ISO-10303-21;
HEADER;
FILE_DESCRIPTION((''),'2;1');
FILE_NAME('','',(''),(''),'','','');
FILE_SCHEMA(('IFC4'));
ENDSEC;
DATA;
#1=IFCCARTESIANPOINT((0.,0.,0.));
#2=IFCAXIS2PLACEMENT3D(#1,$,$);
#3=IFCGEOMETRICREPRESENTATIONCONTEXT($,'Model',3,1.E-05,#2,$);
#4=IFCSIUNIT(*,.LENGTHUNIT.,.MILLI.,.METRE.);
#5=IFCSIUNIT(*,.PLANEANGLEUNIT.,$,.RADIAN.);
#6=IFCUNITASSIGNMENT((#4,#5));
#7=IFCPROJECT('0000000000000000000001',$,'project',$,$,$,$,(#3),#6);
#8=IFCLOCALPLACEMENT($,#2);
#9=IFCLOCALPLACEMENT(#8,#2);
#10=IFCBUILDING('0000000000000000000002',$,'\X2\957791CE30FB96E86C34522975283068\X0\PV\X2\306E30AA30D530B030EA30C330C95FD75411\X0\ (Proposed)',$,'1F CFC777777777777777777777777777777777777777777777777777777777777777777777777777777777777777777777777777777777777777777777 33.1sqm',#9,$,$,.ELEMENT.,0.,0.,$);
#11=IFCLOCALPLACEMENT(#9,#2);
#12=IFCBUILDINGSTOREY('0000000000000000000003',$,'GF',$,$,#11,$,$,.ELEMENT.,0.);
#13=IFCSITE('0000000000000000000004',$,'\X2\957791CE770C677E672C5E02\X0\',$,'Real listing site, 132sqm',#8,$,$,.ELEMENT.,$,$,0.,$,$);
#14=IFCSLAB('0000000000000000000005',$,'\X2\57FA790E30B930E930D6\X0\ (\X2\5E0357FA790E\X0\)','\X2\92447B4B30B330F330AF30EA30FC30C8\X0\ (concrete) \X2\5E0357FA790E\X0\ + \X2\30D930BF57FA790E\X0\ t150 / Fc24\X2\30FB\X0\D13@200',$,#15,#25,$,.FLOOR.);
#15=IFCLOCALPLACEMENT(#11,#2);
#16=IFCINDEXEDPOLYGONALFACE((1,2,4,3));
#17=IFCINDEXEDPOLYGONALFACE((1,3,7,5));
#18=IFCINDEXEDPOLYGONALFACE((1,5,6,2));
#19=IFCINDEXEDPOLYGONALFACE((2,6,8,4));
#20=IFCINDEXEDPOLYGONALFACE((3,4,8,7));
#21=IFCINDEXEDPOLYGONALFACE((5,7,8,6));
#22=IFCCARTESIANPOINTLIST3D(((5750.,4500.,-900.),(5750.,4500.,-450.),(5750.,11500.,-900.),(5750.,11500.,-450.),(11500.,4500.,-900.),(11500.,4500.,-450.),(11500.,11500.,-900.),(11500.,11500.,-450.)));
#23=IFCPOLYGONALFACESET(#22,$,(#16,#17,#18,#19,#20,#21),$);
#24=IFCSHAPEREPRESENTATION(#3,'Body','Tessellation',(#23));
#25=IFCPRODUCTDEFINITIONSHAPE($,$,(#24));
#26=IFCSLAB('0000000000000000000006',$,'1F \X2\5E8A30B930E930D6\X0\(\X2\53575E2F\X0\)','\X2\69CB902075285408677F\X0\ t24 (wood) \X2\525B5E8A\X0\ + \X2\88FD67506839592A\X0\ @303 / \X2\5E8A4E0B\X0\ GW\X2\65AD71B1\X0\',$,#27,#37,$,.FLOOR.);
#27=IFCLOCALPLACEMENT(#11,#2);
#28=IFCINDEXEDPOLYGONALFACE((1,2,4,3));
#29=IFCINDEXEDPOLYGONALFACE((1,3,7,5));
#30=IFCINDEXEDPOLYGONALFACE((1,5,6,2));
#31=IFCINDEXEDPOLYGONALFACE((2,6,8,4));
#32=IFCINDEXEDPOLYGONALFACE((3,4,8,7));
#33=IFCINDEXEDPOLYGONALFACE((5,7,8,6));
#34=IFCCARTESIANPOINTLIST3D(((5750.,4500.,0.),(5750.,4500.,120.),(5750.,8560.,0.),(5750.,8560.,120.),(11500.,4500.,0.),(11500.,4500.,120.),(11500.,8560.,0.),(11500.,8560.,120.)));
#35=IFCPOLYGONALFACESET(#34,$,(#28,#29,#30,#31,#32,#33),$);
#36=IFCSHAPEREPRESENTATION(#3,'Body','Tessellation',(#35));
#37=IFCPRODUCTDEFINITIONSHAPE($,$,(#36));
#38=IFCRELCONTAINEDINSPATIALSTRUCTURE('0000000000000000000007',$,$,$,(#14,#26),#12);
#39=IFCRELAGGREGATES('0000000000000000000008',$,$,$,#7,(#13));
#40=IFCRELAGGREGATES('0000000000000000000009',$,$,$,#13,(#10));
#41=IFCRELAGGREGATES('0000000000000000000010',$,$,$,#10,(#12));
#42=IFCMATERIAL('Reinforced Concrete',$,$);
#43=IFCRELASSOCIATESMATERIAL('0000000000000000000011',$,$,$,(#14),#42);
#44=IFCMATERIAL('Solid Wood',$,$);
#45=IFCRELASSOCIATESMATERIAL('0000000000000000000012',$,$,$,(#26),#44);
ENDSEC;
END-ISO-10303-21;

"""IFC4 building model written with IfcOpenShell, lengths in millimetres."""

from ifc_helpers import new_model, si_unit, frame, frame_2d, origin, place, context, project, spatial, rectangle, extrude, material, element, save


model = new_model("IFC4")

# Units and contexts
model_context = context("Model", 3, precision=1e-05, world=origin())
ifc_project = project(units=[si_unit("LENGTHUNIT", "METRE", prefix="MILLI"), si_unit("PLANEANGLEUNIT", "RADIAN")], contexts=[model_context])

# Site, building, storey
site_placement = place(None, origin())
site = spatial("IfcSite", under=ifc_project, at=site_placement, Name="長野県松本市", ObjectType="Real listing site, 132sqm", CompositionType="ELEMENT", RefElevation=0.0)
building_placement = place(site_placement, origin())
building = spatial("IfcBuilding", under=site, at=building_placement, Name="長野・雨水利用とPVのオフグリッド志向 (Proposed)", ObjectType="1F CFC777777777777777777777777777777777777777777777777777777777777777777777777777777777777777777777777777777777777777777777 33.1sqm", CompositionType="ELEMENT", ElevationOfRefHeight=0.0, ElevationOfTerrain=0.0)
storey_placement = place(building_placement, origin())
storey = spatial("IfcBuildingStorey", under=building, at=storey_placement, Name="GF", CompositionType="ELEMENT", Elevation=0.0)

# Shared definitions
ifc_material_1 = material(Name="Solid Wood")

# Slabs
ifc_material_2 = material(Name="Reinforced Concrete")
slab_1_placement = place(storey_placement, frame((2875.0, 2250.0, -450.0)))
element("IfcSlab", 1, at=slab_1_placement, inside=storey, material=ifc_material_2, Name="基礎スラブ (布基礎)", Description="鉄筋コンクリート (concrete) 布基礎 + ベタ基礎 t150 / Fc24・D13@200", PredefinedType="FLOOR", context=model_context, shape_type="SweptSolid", body=[
    extrude(rectangle(XDim=5750.0, YDim=7000.0, at=frame_2d((2875.0, 3500.0))), frame((2875.0, 2250.0, -450.0)), (0.0, 0.0, 1.0), 450.0),
])
slab_2_placement = place(storey_placement, frame((2875.0, 2250.0, 0.0)))
element("IfcSlab", 2, at=slab_2_placement, inside=storey, material=ifc_material_1, Name="1F 床スラブ(南帯)", Description="構造用合板 t24 (wood) 剛床 + 製材根太 @303 / 床下 GW断熱", PredefinedType="FLOOR", context=model_context, shape_type="SweptSolid", body=[
    extrude(rectangle(XDim=5750.0, YDim=4060.0, at=frame_2d((2875.0, 2030.0))), frame((2875.0, 2250.0, 0.0)), (0.0, 0.0, 1.0), 120.0),
])

save(model, "model.ifc")
